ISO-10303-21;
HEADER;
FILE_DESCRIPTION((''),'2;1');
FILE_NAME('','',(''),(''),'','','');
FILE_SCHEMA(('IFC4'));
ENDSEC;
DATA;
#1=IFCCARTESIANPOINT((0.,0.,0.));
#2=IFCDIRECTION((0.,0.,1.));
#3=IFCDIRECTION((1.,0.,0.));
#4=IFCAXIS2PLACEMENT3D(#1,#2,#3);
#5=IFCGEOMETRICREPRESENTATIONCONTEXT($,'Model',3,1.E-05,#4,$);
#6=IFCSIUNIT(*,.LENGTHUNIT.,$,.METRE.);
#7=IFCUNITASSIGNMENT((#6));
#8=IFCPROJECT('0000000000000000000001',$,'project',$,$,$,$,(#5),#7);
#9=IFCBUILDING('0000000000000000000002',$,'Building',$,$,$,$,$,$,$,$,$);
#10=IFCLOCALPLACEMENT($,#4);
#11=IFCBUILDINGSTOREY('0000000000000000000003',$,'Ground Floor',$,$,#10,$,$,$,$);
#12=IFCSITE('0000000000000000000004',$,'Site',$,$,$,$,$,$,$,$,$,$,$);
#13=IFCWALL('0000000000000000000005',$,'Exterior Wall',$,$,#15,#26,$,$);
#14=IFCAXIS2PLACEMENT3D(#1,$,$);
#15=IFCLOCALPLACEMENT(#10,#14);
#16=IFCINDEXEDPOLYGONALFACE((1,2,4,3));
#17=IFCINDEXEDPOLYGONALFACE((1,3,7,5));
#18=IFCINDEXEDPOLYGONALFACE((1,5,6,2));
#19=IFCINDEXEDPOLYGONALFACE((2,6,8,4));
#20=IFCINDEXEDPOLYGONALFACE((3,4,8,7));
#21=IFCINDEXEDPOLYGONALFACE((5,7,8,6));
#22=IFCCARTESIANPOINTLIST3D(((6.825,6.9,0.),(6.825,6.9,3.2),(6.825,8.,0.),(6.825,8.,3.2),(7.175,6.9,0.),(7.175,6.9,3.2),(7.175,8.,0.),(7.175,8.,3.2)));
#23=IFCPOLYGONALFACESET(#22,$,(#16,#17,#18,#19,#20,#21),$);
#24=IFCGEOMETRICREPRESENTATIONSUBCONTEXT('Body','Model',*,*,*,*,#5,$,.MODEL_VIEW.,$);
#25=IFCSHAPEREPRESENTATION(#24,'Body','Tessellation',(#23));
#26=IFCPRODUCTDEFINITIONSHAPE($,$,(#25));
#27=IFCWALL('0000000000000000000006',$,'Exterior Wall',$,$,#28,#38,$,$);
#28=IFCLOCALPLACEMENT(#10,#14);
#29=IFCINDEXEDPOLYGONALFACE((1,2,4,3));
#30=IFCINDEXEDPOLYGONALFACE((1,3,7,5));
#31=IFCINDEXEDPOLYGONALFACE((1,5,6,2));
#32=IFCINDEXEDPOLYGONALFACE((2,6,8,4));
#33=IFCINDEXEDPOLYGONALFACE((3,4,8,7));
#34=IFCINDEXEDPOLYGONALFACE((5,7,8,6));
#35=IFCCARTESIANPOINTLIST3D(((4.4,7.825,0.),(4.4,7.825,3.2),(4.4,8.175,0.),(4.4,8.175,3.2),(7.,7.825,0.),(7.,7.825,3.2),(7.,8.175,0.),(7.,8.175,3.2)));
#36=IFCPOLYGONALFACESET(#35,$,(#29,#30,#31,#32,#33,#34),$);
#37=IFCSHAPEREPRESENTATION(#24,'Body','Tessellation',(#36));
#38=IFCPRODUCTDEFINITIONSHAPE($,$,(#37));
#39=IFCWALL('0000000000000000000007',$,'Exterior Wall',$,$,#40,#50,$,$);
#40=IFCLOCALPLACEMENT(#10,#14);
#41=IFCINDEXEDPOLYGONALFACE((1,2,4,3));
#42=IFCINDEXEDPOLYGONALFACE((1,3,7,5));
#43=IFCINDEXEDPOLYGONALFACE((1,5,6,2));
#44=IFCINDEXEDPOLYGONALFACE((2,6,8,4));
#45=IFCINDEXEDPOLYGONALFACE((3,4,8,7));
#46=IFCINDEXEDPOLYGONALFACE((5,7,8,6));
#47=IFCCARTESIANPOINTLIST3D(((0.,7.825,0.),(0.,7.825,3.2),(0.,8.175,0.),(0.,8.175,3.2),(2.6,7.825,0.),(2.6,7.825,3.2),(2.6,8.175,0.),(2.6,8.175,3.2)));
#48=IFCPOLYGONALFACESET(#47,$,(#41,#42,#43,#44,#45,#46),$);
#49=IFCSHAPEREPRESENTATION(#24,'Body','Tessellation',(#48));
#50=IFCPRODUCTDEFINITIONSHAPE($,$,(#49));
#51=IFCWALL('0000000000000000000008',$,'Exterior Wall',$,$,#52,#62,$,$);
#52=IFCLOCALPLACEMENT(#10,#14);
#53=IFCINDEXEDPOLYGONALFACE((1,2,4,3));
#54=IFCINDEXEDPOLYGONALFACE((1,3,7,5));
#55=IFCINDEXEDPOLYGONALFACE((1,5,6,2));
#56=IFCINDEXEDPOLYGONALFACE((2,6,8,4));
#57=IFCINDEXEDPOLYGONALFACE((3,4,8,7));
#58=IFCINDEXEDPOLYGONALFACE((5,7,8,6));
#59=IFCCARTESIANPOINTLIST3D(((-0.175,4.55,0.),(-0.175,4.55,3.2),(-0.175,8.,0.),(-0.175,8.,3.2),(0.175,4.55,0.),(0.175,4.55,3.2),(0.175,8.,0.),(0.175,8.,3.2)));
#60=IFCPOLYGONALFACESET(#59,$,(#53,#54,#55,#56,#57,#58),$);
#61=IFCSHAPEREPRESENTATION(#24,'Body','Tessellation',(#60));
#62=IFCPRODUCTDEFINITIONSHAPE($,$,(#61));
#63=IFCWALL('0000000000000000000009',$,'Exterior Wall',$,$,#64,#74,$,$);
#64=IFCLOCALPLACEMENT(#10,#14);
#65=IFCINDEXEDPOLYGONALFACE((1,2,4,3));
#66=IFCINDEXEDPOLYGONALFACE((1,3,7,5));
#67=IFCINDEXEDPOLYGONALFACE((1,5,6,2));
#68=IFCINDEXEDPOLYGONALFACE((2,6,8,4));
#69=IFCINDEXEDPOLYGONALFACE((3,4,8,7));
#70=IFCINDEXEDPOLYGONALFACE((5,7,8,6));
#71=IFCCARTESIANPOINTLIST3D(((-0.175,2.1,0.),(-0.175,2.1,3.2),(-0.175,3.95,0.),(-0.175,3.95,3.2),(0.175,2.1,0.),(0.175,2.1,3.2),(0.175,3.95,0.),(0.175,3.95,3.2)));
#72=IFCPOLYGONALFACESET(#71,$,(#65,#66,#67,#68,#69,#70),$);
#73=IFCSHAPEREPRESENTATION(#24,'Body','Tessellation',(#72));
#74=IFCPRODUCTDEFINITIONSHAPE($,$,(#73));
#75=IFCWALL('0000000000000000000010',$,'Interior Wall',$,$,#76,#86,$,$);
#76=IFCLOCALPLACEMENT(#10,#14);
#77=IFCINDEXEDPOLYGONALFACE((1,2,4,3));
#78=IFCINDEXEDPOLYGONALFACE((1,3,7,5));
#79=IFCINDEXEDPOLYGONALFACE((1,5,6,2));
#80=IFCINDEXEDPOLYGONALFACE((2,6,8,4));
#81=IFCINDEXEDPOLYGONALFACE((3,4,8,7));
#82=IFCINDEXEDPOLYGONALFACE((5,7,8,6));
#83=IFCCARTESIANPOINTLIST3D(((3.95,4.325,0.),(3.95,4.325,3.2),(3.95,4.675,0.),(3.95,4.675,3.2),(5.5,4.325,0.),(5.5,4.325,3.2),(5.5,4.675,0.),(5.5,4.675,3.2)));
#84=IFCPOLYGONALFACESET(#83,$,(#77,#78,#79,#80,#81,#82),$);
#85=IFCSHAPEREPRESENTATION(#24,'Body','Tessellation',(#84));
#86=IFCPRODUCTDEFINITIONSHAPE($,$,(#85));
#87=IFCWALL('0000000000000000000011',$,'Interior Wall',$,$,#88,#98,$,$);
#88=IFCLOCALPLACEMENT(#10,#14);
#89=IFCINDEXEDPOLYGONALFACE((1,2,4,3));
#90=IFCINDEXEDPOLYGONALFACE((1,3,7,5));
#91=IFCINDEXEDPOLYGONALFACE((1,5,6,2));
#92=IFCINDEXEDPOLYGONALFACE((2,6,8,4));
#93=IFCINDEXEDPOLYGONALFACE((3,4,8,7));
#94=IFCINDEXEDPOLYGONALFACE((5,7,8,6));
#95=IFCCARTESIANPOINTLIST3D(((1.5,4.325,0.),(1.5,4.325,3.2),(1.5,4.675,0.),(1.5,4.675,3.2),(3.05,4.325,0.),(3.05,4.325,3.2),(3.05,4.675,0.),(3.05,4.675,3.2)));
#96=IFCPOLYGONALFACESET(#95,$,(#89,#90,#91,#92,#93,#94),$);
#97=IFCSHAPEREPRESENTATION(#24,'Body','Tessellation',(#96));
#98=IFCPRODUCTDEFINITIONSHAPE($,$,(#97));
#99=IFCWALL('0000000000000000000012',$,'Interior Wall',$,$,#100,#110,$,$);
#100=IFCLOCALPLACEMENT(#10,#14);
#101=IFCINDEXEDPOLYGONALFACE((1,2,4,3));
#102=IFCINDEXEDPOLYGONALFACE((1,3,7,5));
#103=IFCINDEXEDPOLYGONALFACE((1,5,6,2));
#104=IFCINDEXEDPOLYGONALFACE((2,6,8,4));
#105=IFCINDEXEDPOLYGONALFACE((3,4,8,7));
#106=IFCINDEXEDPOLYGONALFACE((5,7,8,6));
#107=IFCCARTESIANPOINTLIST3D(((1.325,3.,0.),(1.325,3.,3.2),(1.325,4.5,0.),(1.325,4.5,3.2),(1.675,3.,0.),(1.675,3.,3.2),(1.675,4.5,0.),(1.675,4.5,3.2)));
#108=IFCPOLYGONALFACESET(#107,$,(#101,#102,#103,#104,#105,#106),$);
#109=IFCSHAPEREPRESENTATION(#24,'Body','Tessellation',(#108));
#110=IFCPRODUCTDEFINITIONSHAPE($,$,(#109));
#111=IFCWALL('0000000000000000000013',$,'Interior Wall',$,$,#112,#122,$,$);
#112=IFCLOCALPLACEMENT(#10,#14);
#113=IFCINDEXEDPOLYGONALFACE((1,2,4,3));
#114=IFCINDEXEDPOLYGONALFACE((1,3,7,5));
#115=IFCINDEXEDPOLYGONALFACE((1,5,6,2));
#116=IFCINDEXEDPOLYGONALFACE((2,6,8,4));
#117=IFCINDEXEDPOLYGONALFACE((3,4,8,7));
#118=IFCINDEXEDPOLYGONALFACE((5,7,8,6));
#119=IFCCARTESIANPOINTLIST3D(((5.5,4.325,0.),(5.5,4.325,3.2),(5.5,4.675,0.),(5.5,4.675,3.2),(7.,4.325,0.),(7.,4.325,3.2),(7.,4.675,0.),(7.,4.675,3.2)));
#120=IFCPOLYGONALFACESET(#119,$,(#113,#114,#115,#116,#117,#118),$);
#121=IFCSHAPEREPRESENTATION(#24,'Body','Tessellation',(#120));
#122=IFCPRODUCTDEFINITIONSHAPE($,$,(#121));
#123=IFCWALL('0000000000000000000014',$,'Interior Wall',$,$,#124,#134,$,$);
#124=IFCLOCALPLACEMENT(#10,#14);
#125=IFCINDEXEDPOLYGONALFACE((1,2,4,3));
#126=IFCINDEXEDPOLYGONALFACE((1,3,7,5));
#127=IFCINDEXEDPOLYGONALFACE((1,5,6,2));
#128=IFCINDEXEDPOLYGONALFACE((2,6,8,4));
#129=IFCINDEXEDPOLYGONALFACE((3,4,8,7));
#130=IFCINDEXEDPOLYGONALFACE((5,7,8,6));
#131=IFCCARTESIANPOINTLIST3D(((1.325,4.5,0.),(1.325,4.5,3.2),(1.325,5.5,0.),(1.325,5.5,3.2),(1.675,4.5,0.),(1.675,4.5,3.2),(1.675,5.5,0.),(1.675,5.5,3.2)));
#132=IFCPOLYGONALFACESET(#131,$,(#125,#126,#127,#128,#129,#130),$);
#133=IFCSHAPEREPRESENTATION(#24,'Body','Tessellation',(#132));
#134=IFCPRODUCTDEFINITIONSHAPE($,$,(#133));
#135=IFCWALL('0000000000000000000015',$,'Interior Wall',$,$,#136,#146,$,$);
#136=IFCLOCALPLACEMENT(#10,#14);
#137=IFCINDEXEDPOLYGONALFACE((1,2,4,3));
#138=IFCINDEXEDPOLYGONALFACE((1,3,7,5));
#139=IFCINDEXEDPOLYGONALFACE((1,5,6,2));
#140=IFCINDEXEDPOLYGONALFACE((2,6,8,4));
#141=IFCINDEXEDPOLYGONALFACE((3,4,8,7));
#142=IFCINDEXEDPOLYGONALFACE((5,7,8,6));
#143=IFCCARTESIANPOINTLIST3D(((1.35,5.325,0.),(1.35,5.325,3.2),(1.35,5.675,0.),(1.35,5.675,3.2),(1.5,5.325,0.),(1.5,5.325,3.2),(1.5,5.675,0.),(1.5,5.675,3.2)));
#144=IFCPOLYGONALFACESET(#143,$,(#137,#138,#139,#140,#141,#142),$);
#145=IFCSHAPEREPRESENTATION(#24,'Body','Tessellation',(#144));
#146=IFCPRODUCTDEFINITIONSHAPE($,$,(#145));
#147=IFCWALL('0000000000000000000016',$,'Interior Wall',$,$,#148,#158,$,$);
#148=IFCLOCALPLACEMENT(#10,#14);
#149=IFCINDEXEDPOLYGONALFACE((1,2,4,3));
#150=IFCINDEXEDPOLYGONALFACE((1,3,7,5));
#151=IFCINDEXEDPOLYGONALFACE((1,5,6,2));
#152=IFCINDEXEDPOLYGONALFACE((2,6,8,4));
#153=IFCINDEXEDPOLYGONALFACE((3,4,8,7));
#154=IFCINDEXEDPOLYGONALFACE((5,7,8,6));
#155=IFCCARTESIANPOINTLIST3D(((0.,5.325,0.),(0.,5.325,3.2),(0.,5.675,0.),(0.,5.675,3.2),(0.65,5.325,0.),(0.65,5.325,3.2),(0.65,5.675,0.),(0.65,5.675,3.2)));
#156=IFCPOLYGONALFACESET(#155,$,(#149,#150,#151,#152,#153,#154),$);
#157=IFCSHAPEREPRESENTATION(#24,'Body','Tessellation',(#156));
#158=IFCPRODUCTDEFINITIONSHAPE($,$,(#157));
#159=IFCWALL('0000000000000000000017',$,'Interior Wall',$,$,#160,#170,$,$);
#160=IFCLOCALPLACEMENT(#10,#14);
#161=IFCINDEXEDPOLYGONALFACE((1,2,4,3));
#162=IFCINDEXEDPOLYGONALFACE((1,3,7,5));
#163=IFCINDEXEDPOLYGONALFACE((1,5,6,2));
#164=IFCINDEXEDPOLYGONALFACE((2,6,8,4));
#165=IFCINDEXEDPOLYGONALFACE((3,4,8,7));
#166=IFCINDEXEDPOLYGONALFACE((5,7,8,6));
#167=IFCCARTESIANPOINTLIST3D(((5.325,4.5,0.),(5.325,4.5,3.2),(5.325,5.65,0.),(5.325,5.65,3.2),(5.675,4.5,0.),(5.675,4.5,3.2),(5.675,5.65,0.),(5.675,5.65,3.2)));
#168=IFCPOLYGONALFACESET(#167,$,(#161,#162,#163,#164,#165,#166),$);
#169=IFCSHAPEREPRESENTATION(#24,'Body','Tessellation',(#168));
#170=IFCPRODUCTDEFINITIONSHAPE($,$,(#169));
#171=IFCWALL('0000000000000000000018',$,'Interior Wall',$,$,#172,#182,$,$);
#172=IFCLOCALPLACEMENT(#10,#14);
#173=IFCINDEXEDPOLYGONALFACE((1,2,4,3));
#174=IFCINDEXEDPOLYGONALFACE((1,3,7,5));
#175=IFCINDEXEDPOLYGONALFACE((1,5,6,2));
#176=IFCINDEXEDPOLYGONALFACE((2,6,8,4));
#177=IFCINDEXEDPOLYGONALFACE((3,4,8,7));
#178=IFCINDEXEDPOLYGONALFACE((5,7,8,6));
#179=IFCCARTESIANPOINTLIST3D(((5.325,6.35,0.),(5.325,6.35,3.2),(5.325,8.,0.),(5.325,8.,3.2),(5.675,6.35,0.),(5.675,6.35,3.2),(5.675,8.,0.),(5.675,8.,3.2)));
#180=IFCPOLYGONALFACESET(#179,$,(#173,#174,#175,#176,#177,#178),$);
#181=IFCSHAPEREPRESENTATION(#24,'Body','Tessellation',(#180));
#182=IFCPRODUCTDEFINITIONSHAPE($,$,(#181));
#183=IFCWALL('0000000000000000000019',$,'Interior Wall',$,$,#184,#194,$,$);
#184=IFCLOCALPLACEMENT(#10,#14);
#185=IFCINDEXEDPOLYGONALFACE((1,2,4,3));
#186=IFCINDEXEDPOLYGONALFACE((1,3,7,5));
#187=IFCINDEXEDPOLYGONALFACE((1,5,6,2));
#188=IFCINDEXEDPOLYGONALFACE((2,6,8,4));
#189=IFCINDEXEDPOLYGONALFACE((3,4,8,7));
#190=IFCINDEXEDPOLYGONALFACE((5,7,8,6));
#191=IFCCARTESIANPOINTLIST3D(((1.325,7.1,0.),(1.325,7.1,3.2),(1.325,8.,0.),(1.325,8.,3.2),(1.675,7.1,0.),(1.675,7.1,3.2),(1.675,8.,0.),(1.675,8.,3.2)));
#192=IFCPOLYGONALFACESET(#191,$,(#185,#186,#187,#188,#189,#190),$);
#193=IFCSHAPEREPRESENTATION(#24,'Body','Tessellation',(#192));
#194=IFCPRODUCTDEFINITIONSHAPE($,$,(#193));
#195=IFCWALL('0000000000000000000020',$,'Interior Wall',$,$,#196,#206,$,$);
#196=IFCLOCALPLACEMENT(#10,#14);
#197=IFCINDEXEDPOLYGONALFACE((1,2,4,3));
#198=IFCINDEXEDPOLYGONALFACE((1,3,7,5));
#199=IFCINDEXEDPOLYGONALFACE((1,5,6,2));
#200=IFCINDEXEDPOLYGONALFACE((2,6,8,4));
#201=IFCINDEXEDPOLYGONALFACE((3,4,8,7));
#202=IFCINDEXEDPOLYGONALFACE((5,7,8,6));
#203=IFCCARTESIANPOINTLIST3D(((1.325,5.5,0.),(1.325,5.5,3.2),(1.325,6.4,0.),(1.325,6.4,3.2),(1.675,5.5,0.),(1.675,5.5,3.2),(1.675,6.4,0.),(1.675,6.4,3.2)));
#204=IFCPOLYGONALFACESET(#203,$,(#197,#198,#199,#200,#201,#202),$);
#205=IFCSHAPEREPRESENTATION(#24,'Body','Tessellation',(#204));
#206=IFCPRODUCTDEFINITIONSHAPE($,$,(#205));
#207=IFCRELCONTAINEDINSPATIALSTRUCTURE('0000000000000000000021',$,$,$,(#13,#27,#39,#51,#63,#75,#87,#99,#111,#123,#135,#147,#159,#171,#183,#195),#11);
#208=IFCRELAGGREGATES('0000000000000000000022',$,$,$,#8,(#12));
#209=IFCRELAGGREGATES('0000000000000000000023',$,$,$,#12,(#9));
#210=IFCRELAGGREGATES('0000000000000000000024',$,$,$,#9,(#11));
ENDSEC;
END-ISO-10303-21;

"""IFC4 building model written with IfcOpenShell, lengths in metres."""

from ifc_helpers import new_model, si_unit, frame, origin_with_axes, place, context, subcontext, project, spatial, indexed_curve, outline, extrude, element, save


model = new_model("IFC4")

# Units and contexts
model_context = context("Model", 3, precision=1e-05, world=origin_with_axes())
body_context = subcontext(model_context, "Body", "Model", "MODEL_VIEW")
ifc_project = project(units=[si_unit("LENGTHUNIT", "METRE")], contexts=[model_context])

# Site, building, storey
site = spatial("IfcSite", under=ifc_project, Name="Site")
building = spatial("IfcBuilding", under=site, Name="Building")
storey_placement = place(None, origin_with_axes())
storey = spatial("IfcBuildingStorey", under=building, at=storey_placement, Name="Ground Floor")

# Walls
wall_1_placement = place(storey_placement, frame((7.0, 6.9, 0.0), z_axis=(0.0, 0.0, 1.0), x_axis=(0.0, 1.0, 0.0)))
element("IfcWall", 1, at=wall_1_placement, inside=storey, Name="Exterior Wall", context=body_context, shape_type="SweptSolid", body=[
    extrude(outline(indexed_curve([(0.0, 0.0), (0.0, 0.35), (1.1, 0.35), (1.1, 0.0), (0.0, 0.0)], self_intersect=False)), frame((0.0, -0.175, 0.0), z_axis=(0.0, 0.0, 1.0), x_axis=(1.0, 0.0, 0.0)), (0.0, 0.0, 1.0), 3.2),
])
for number, where, z_axis, x_axis, name in (
    (2, (7.0, 8.0, 0.0), (0.0, 0.0, 1.0), (-1.0, 0.0, 0.0), "Exterior Wall"),
    (3, (2.6, 8.0, 0.0), (0.0, 0.0, 1.0), (-1.0, 0.0, 0.0), "Exterior Wall"),
):
    element("IfcWall", number, at=place(storey_placement, frame(where, z_axis=z_axis, x_axis=x_axis)), inside=storey, Name=name, context=body_context, shape_type="SweptSolid", body=[
        extrude(outline(indexed_curve([(0.0, 0.0), (0.0, 0.35), (2.6, 0.35), (2.6, 0.0), (0.0, 0.0)], self_intersect=False)), frame((0.0, -0.175, 0.0), z_axis=(0.0, 0.0, 1.0), x_axis=(1.0, 0.0, 0.0)), (0.0, 0.0, 1.0), 3.2),
    ])
wall_2_placement = place(storey_placement, frame((0.0, 8.0, 0.0), z_axis=(0.0, 0.0, 1.0), x_axis=(0.0, -1.0, 0.0)))
element("IfcWall", 4, at=wall_2_placement, inside=storey, Name="Exterior Wall", context=body_context, shape_type="SweptSolid", body=[
    extrude(outline(indexed_curve([(0.0, 0.0), (0.0, 0.35), (3.45, 0.35), (3.45, 0.0), (0.0, 0.0)], self_intersect=False)), frame((0.0, -0.175, 0.0), z_axis=(0.0, 0.0, 1.0), x_axis=(1.0, 0.0, 0.0)), (0.0, 0.0, 1.0), 3.2),
])
wall_3_placement = place(storey_placement, frame((0.0, 3.95, 0.0), z_axis=(0.0, 0.0, 1.0), x_axis=(0.0, -1.0, 0.0)))
element("IfcWall", 5, at=wall_3_placement, inside=storey, Name="Exterior Wall", context=body_context, shape_type="SweptSolid", body=[
    extrude(outline(indexed_curve([(0.0, 0.0), (0.0, 0.35), (1.85, 0.35), (1.85, 0.0), (0.0, 0.0)], self_intersect=False)), frame((0.0, -0.175, 0.0), z_axis=(0.0, 0.0, 1.0), x_axis=(1.0, 0.0, 0.0)), (0.0, 0.0, 1.0), 3.2),
])
for number, where, z_axis, x_axis, name in (
    (6, (5.5, 4.5, 0.0), (0.0, 0.0, 1.0), (-1.0, 0.0, 0.0), "Interior Wall"),
    (7, (3.05, 4.5, 0.0), (0.0, 0.0, 1.0), (-1.0, 0.0, 0.0), "Interior Wall"),
):
    element("IfcWall", number, at=place(storey_placement, frame(where, z_axis=z_axis, x_axis=x_axis)), inside=storey, Name=name, context=body_context, shape_type="SweptSolid", body=[
        extrude(outline(indexed_curve([(0.0, 0.0), (0.0, 0.35), (1.55, 0.35), (1.55, 0.0), (0.0, 0.0)], self_intersect=False)), frame((0.0, -0.175, 0.0), z_axis=(0.0, 0.0, 1.0), x_axis=(1.0, 0.0, 0.0)), (0.0, 0.0, 1.0), 3.2),
    ])
for number, where, z_axis, x_axis, name in (
    (8, (1.5, 4.5, 0.0), (0.0, 0.0, 1.0), (0.0, -1.0, 0.0), "Interior Wall"),
    (9, (7.0, 4.5, 0.0), (0.0, 0.0, 1.0), (-1.0, 0.0, 0.0), "Interior Wall"),
):
    element("IfcWall", number, at=place(storey_placement, frame(where, z_axis=z_axis, x_axis=x_axis)), inside=storey, Name=name, context=body_context, shape_type="SweptSolid", body=[
        extrude(outline(indexed_curve([(0.0, 0.0), (0.0, 0.35), (1.5, 0.35), (1.5, 0.0), (0.0, 0.0)], self_intersect=False)), frame((0.0, -0.175, 0.0), z_axis=(0.0, 0.0, 1.0), x_axis=(1.0, 0.0, 0.0)), (0.0, 0.0, 1.0), 3.2),
    ])
wall_4_placement = place(storey_placement, frame((1.5, 4.5, 0.0), z_axis=(0.0, 0.0, 1.0), x_axis=(0.0, 1.0, 0.0)))
element("IfcWall", 10, at=wall_4_placement, inside=storey, Name="Interior Wall", context=body_context, shape_type="SweptSolid", body=[
    extrude(outline(indexed_curve([(0.0, 0.0), (0.0, 0.35), (1.0, 0.35), (1.0, 0.0), (0.0, 0.0)], self_intersect=False)), frame((0.0, -0.175, 0.0), z_axis=(0.0, 0.0, 1.0), x_axis=(1.0, 0.0, 0.0)), (0.0, 0.0, 1.0), 3.2),
])
wall_5_placement = place(storey_placement, frame((1.5, 5.5, 0.0), z_axis=(0.0, 0.0, 1.0), x_axis=(-1.0, 0.0, 0.0)))
element("IfcWall", 11, at=wall_5_placement, inside=storey, Name="Interior Wall", context=body_context, shape_type="SweptSolid", body=[
    extrude(outline(indexed_curve([(0.0, 0.0), (0.0, 0.35), (0.15, 0.35), (0.15, 0.0), (0.0, 0.0)], self_intersect=False)), frame((0.0, -0.175, 0.0), z_axis=(0.0, 0.0, 1.0), x_axis=(1.0, 0.0, 0.0)), (0.0, 0.0, 1.0), 3.2),
])
wall_6_placement = place(storey_placement, frame((0.65, 5.5, 0.0), z_axis=(0.0, 0.0, 1.0), x_axis=(-1.0, 0.0, 0.0)))
element("IfcWall", 12, at=wall_6_placement, inside=storey, Name="Interior Wall", context=body_context, shape_type="SweptSolid", body=[
    extrude(outline(indexed_curve([(0.0, 0.0), (0.0, 0.35), (0.65, 0.35), (0.65, 0.0), (0.0, 0.0)], self_intersect=False)), frame((0.0, -0.175, 0.0), z_axis=(0.0, 0.0, 1.0), x_axis=(1.0, 0.0, 0.0)), (0.0, 0.0, 1.0), 3.2),
])
wall_7_placement = place(storey_placement, frame((5.5, 4.5, 0.0), z_axis=(0.0, 0.0, 1.0), x_axis=(0.0, 1.0, 0.0)))
element("IfcWall", 13, at=wall_7_placement, inside=storey, Name="Interior Wall", context=body_context, shape_type="SweptSolid", body=[
    extrude(outline(indexed_curve([(0.0, 0.0), (0.0, 0.35), (1.15, 0.35), (1.15, 0.0), (0.0, 0.0)], self_intersect=False)), frame((0.0, -0.175, 0.0), z_axis=(0.0, 0.0, 1.0), x_axis=(1.0, 0.0, 0.0)), (0.0, 0.0, 1.0), 3.2),
])
wall_8_placement = place(storey_placement, frame((5.5, 6.35, 0.0), z_axis=(0.0, 0.0, 1.0), x_axis=(0.0, 1.0, 0.0)))
element("IfcWall", 14, at=wall_8_placement, inside=storey, Name="Interior Wall", context=body_context, shape_type="SweptSolid", body=[
    extrude(outline(indexed_curve([(0.0, 0.0), (0.0, 0.35), (1.65, 0.35), (1.65, 0.0), (0.0, 0.0)], self_intersect=False)), frame((0.0, -0.175, 0.0), z_axis=(0.0, 0.0, 1.0), x_axis=(1.0, 0.0, 0.0)), (0.0, 0.0, 1.0), 3.2),
])
for number, where, z_axis, x_axis, name in (
    (15, (1.5, 8.0, 0.0), (0.0, 0.0, 1.0), (0.0, -1.0, 0.0), "Interior Wall"),
    (16, (1.5, 6.4, 0.0), (0.0, 0.0, 1.0), (0.0, -1.0, 0.0), "Interior Wall"),
):
    element("IfcWall", number, at=place(storey_placement, frame(where, z_axis=z_axis, x_axis=x_axis)), inside=storey, Name=name, context=body_context, shape_type="SweptSolid", body=[
        extrude(outline(indexed_curve([(0.0, 0.0), (0.0, 0.35), (0.9, 0.35), (0.9, 0.0), (0.0, 0.0)], self_intersect=False)), frame((0.0, -0.175, 0.0), z_axis=(0.0, 0.0, 1.0), x_axis=(1.0, 0.0, 0.0)), (0.0, 0.0, 1.0), 3.2),
    ])

save(model, "model.ifc")
